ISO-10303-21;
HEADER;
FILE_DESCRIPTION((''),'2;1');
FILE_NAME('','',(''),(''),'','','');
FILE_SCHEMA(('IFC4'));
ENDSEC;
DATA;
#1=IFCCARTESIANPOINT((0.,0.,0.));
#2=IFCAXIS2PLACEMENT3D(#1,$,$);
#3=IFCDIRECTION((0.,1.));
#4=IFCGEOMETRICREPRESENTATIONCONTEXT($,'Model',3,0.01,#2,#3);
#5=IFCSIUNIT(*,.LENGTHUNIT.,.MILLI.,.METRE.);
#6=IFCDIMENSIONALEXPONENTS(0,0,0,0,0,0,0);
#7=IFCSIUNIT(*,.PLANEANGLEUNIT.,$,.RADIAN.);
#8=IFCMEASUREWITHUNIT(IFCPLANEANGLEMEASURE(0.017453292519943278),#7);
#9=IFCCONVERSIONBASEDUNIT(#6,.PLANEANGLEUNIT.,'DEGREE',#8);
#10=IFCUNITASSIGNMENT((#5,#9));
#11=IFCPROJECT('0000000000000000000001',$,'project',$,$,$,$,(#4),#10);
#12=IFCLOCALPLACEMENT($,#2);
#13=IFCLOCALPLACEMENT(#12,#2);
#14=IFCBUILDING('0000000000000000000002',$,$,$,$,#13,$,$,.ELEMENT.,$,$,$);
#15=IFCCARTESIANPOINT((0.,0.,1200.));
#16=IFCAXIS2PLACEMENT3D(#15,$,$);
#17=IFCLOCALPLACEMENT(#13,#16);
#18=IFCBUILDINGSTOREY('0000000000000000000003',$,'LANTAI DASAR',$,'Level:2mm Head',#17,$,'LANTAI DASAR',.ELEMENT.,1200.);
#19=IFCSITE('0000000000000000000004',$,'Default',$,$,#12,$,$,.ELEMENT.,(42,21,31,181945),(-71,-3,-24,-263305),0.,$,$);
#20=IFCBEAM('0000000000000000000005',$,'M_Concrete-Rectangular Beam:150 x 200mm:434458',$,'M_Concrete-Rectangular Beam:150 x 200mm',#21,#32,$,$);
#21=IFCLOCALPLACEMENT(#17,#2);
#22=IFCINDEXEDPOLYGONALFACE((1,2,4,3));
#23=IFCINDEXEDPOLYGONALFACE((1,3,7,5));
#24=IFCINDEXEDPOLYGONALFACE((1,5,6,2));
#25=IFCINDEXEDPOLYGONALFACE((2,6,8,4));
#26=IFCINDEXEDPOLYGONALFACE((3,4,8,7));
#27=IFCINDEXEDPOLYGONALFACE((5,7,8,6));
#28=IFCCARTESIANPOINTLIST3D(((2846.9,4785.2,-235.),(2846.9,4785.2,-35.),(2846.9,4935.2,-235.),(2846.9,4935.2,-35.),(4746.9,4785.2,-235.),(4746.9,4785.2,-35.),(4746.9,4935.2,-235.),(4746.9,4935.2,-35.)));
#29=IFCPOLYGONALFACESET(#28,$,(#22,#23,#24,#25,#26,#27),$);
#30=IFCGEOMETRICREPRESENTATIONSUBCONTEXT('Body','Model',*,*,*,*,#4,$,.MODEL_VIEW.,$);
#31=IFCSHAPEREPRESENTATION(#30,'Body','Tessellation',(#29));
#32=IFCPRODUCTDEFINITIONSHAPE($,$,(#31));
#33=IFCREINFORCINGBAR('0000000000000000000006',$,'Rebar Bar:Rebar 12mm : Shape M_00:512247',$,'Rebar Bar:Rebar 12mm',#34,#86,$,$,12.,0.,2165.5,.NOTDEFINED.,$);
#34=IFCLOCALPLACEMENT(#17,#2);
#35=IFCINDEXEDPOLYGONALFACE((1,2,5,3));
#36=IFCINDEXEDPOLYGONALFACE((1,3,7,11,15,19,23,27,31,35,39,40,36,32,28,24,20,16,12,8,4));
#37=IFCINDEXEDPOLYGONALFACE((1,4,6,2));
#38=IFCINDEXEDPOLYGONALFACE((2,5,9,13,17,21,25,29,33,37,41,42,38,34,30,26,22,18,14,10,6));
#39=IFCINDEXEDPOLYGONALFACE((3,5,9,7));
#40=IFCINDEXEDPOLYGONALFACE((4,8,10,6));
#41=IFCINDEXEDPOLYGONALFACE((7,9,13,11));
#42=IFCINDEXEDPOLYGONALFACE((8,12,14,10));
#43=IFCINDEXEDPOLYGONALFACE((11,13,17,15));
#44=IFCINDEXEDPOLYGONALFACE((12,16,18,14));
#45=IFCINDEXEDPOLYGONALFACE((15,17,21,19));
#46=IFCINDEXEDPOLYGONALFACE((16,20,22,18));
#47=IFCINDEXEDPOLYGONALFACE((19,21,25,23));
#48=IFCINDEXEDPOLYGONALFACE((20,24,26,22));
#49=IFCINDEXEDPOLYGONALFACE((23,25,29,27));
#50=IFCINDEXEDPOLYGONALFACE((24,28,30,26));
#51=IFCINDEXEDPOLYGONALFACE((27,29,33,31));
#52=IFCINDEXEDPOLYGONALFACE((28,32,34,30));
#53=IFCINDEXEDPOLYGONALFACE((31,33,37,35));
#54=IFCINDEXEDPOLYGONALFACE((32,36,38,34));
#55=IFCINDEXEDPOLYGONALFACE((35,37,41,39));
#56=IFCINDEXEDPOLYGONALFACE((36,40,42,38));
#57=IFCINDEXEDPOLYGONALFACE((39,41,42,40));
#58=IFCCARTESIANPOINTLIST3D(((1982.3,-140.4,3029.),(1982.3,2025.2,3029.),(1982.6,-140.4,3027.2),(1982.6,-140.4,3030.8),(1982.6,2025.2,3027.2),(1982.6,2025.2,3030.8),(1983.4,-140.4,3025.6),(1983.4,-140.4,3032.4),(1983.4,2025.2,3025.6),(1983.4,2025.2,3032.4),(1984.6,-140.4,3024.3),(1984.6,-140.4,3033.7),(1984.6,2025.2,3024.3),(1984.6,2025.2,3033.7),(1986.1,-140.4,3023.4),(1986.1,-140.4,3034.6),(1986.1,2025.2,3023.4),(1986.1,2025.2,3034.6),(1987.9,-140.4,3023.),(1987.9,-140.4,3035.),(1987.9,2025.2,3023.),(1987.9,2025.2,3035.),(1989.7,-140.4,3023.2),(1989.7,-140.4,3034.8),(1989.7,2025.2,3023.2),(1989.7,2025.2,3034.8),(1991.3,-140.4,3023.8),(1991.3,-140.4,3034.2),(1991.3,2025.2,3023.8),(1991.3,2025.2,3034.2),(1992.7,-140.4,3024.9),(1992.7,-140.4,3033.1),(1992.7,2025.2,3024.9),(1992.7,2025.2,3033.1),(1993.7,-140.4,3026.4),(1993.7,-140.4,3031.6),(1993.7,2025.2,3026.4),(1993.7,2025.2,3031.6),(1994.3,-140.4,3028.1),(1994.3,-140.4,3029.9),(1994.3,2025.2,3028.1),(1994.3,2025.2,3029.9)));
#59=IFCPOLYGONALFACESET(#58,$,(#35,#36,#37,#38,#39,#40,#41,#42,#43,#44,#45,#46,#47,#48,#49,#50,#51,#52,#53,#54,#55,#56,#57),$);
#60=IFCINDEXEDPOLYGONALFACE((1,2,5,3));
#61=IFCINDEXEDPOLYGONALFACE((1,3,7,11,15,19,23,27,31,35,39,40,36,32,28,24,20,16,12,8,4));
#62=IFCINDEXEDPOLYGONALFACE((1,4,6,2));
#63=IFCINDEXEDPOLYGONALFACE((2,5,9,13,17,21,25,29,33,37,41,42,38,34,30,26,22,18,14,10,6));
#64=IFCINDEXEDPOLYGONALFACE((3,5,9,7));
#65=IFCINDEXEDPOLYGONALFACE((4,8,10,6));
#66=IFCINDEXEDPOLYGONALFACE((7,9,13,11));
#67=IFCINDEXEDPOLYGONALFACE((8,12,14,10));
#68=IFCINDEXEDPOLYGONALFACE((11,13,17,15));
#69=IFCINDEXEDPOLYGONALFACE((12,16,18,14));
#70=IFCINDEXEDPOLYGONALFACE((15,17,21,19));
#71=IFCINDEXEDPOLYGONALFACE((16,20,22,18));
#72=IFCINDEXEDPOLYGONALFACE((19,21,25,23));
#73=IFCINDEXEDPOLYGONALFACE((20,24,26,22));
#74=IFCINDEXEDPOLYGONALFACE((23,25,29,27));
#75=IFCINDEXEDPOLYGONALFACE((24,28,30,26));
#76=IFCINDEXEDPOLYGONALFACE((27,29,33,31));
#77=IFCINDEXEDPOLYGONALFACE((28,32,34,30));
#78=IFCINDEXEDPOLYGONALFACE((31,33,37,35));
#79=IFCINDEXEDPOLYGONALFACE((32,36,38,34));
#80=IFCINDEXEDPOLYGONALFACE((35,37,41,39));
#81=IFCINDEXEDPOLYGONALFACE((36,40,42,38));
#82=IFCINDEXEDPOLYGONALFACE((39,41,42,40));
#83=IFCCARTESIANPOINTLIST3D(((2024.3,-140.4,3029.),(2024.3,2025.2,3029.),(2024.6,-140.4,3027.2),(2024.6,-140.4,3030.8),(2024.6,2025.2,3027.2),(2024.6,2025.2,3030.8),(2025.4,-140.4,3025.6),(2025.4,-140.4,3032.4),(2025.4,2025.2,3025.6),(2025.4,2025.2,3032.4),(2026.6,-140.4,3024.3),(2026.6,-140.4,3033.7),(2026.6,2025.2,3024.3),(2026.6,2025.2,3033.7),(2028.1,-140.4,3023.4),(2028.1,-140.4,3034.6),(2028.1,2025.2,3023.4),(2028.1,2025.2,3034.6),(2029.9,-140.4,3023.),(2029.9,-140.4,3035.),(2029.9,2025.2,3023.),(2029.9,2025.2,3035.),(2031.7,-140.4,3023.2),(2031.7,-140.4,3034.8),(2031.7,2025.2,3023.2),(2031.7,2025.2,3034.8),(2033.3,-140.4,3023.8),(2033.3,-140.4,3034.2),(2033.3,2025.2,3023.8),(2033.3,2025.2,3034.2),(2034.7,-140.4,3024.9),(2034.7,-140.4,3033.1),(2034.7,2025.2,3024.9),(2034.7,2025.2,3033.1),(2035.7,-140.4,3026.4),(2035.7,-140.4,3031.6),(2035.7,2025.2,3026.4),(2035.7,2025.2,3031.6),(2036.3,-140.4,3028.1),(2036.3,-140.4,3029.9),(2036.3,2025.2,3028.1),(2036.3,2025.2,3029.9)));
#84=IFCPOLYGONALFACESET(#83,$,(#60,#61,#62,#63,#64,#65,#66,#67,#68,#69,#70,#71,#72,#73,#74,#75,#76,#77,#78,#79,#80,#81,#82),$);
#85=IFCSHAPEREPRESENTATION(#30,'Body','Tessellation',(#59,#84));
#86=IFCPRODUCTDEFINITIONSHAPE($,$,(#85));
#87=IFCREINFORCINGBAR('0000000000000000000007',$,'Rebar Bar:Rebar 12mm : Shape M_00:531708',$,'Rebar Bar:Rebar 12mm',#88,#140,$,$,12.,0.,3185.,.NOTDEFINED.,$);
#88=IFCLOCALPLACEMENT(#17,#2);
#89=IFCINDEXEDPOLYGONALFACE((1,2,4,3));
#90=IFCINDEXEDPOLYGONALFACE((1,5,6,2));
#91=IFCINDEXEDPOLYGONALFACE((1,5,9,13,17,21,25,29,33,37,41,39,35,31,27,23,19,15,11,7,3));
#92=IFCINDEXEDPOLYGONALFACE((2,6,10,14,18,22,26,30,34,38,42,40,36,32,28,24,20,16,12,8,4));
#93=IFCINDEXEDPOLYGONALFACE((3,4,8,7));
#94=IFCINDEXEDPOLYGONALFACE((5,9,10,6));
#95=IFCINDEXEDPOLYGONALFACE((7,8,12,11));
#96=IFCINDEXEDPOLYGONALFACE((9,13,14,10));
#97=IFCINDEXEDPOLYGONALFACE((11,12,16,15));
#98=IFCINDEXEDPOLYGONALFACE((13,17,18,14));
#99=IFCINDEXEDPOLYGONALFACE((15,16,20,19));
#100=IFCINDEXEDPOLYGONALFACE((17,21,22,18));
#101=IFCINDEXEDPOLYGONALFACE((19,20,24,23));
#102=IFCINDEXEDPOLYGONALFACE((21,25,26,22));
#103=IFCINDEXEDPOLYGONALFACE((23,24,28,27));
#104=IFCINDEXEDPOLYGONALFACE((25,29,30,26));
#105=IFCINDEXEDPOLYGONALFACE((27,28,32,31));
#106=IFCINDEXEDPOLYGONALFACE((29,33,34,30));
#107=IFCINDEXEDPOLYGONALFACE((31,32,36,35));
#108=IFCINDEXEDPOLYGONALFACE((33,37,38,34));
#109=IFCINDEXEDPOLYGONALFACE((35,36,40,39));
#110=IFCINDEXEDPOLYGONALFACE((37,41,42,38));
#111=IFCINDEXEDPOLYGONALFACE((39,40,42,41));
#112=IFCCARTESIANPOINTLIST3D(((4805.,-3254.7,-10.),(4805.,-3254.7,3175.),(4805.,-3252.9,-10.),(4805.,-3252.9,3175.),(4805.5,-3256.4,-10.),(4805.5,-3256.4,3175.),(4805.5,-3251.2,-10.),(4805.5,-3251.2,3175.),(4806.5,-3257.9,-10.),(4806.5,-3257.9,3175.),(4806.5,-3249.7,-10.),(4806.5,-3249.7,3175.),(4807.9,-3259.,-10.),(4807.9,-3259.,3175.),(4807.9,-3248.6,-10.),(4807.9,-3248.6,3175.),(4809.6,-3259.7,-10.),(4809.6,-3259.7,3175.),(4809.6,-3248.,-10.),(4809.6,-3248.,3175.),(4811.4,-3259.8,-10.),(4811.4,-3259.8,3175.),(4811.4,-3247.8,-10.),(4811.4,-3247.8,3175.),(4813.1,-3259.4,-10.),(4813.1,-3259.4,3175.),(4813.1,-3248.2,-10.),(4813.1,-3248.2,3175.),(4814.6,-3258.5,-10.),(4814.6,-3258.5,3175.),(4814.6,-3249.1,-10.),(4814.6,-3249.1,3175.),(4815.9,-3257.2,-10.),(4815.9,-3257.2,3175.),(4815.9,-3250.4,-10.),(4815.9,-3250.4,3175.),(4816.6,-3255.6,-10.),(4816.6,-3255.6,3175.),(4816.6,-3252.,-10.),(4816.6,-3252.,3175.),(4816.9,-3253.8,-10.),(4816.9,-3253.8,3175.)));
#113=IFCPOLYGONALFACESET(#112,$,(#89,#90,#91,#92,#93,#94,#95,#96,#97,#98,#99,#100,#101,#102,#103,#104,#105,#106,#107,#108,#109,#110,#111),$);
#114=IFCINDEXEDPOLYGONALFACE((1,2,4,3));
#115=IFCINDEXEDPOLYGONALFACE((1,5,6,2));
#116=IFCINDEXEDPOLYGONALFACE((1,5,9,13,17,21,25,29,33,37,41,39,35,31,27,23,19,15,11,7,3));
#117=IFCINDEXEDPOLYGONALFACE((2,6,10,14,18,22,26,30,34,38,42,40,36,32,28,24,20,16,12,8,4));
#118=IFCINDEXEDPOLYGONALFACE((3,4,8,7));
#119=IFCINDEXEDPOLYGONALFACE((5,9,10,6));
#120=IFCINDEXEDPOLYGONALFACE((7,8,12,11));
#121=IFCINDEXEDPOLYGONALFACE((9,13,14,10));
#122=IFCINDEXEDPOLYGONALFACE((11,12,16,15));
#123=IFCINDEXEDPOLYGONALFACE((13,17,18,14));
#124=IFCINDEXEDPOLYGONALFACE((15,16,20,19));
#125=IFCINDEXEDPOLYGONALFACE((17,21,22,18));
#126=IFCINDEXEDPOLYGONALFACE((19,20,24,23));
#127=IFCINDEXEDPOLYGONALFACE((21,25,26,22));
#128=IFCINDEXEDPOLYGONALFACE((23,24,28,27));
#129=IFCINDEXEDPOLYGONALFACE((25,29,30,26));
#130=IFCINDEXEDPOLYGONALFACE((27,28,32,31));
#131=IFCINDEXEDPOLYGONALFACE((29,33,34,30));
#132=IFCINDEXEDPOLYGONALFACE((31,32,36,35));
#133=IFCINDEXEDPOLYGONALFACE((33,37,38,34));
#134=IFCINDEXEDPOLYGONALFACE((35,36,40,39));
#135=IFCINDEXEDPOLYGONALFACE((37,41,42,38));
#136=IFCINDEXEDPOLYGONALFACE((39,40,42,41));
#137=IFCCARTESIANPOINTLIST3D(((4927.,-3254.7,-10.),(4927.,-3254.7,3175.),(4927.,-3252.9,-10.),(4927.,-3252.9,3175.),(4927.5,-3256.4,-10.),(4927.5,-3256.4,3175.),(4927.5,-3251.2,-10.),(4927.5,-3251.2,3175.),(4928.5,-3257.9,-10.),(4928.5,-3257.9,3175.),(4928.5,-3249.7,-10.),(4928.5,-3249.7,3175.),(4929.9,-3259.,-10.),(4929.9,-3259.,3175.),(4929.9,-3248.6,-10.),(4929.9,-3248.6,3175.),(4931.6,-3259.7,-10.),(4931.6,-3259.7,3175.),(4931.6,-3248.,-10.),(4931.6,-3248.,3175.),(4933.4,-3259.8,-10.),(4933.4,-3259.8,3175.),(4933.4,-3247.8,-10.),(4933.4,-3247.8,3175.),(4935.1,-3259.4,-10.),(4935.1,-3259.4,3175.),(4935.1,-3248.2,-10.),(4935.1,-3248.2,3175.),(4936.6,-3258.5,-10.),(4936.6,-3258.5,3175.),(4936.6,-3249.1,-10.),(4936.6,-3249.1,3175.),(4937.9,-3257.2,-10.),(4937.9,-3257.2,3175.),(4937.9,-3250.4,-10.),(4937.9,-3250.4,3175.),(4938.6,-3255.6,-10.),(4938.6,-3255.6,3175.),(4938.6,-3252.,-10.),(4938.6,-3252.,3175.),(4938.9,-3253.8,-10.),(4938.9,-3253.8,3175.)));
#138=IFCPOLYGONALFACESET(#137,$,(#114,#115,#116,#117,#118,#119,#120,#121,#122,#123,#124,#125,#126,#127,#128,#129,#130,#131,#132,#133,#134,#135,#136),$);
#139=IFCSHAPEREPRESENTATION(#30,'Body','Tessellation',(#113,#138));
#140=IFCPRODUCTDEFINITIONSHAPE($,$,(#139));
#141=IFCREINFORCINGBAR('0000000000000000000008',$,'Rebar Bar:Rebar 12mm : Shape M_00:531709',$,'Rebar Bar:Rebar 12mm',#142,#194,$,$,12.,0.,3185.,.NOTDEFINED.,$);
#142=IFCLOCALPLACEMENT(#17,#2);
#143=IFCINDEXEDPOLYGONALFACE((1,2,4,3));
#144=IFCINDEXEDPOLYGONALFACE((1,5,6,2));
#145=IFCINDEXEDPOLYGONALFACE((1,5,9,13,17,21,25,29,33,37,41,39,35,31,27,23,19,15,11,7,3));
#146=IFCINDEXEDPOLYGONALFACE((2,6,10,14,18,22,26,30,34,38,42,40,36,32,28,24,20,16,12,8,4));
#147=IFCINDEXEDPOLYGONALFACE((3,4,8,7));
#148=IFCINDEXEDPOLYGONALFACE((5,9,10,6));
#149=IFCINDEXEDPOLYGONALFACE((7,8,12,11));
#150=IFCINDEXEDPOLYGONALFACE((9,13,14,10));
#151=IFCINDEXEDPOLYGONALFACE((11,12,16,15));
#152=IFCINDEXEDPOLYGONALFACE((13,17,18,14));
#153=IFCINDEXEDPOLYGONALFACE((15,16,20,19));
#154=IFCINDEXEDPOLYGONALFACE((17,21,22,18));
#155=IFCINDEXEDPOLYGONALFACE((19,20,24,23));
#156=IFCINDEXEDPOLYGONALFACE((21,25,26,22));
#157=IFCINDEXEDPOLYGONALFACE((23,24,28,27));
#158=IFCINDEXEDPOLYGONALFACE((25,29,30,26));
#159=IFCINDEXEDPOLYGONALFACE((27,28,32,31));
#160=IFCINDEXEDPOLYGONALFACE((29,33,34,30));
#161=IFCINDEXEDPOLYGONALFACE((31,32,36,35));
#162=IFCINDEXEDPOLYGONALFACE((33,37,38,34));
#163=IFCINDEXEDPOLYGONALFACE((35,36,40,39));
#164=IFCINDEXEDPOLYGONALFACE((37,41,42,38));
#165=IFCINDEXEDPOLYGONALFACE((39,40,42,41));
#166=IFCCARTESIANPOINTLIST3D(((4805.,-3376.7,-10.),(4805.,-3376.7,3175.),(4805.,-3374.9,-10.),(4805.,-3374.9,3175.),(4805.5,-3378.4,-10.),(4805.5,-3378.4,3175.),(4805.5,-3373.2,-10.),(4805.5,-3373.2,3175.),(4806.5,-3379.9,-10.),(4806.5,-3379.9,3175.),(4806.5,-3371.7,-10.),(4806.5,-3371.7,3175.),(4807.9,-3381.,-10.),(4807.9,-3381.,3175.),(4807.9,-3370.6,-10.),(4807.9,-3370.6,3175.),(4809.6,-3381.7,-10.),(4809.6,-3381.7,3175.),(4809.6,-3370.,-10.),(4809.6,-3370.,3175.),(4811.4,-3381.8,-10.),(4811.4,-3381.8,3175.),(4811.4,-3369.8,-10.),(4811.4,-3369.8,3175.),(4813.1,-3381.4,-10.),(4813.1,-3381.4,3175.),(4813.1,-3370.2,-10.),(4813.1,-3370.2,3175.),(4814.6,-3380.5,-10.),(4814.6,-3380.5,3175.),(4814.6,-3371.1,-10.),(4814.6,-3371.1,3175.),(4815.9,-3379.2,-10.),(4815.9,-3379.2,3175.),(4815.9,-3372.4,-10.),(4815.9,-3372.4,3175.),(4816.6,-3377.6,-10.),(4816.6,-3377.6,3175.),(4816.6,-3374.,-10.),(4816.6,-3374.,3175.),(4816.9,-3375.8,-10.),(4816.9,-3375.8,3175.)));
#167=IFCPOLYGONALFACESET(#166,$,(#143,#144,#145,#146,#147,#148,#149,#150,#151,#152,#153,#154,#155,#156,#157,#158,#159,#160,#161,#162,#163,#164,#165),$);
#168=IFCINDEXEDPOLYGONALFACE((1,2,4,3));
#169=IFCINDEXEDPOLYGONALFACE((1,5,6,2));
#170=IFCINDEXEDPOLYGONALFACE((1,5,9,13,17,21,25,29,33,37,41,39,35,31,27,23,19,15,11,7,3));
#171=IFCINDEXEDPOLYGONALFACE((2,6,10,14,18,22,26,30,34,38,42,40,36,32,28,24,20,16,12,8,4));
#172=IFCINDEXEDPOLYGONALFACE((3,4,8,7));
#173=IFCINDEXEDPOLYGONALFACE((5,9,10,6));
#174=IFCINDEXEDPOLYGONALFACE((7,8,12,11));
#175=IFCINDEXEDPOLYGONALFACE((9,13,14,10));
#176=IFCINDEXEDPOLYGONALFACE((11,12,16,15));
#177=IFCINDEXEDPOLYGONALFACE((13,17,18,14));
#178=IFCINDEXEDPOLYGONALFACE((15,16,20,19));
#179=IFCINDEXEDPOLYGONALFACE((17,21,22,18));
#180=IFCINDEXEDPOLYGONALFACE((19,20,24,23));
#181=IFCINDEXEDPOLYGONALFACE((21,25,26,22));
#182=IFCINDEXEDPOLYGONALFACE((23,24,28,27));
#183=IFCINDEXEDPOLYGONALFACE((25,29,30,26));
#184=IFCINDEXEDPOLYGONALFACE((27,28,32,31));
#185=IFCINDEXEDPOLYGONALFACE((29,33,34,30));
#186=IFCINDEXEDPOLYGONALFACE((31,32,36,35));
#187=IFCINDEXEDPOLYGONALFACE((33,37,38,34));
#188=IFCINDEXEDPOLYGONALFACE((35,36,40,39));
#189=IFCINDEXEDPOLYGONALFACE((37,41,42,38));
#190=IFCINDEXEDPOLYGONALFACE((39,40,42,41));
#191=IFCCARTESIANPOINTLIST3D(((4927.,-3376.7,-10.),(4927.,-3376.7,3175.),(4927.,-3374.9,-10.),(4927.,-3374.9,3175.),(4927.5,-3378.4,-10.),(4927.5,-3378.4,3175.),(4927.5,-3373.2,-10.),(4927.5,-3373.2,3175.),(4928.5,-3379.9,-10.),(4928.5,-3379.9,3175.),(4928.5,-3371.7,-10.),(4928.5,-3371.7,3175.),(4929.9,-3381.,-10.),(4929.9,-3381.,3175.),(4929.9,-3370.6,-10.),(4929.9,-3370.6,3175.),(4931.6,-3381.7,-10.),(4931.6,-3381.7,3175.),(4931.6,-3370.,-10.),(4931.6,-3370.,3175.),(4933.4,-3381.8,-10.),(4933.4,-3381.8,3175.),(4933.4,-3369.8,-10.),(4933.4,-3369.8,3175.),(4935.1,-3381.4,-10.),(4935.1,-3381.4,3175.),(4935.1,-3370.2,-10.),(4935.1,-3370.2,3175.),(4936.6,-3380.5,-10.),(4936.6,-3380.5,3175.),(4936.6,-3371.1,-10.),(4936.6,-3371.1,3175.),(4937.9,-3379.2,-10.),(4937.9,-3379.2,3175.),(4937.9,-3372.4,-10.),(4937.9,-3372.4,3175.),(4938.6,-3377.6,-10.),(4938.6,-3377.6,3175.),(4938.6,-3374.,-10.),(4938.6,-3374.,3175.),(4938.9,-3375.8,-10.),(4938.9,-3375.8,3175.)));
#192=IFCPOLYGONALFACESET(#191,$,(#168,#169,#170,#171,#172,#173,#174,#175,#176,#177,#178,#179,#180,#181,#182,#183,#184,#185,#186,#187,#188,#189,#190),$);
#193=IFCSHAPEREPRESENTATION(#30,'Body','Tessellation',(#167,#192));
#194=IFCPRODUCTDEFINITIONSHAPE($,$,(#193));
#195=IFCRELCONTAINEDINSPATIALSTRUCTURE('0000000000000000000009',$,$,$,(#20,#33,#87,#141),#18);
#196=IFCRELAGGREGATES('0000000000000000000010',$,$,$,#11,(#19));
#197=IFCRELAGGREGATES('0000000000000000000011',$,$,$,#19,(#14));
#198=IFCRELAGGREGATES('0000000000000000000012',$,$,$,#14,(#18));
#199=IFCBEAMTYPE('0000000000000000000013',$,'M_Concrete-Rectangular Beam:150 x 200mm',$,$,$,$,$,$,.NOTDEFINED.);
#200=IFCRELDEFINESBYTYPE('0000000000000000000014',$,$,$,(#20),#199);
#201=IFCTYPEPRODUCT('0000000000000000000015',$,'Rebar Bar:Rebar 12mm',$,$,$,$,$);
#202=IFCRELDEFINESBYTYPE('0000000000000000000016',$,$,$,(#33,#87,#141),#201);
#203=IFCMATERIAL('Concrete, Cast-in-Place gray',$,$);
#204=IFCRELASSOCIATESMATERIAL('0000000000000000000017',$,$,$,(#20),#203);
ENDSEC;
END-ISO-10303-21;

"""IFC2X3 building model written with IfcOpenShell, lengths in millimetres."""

from ifc_helpers import new_model, entity, si_unit, converted_unit, direction, frame, frame_2d, origin, place, context, subcontext, project, spatial, rectangle, extrude, material, type_object, element, save


model = new_model("IFC2X3")

# Units and contexts
model_context = context("Model", 3, precision=0.01, world=origin(), true_north=direction((0.0, 1.0)))
body_context = subcontext(model_context, "Body", "Model", "MODEL_VIEW")
ifc_project = project(units=[si_unit("LENGTHUNIT", "METRE", prefix="MILLI"), converted_unit("PLANEANGLEUNIT", "DEGREE", entity("IfcPlaneAngleMeasure", 0.017453292519943278), si_unit("PLANEANGLEUNIT", "RADIAN"), dimensions=[0, 0, 0, 0, 0, 0, 0])], contexts=[model_context])

# Site, building, storey
site_placement = place(None, origin())
site = spatial("IfcSite", under=ifc_project, at=site_placement, Name="Default", CompositionType="ELEMENT", RefLatitude=(42, 21, 31, 181945), RefLongitude=(-71, -3, -24, -263305), RefElevation=0.0)
building_placement = place(site_placement, origin())
building = spatial("IfcBuilding", under=site, at=building_placement, CompositionType="ELEMENT")
storey_placement = place(building_placement, frame((0.0, 0.0, 1200.0)))
storey = spatial("IfcBuildingStorey", under=building, at=storey_placement, Name="LANTAI DASAR", ObjectType="Level:2mm Head", LongName="LANTAI DASAR", CompositionType="ELEMENT", Elevation=1200.0)

# Shared definitions
ifc_material = material(Name="Concrete, Cast-in-Place gray")

# Beam
beam_type = type_object("IfcBeamType", Name="M_Concrete-Rectangular Beam:150 x 200mm", PredefinedType="NOTDEFINED")
beam_1_placement = place(storey_placement, frame((2721.9, 4860.2, -35.0)))
element("IfcBeam", 1, at=beam_1_placement, inside=storey, type_object=beam_type, material=ifc_material, Name="M_Concrete-Rectangular Beam:150 x 200mm:434458", ObjectType="M_Concrete-Rectangular Beam:150 x 200mm", context=body_context, shape_type="SweptSolid", body=[
    extrude(rectangle(XDim=200.0, YDim=150.0, at=frame_2d((0.0, 0.0), x_axis=(1.0, 0.0))), frame((125.0, 0.0, -100.0), z_axis=(1.0, 0.0, 0.0), x_axis=(0.0, 0.0, -1.0)), (0.0, 0.0, 1.0), 1900.0),
])

# Reinforcing bars
type_product_1 = type_object("IfcTypeProduct", Name="Rebar Bar:Rebar 12mm")
reinforcing_bar_1_placement = place(storey_placement, origin())
element("IfcReinforcingBar", 2, at=reinforcing_bar_1_placement, inside=storey, type_object=type_product_1, Name="Rebar Bar:Rebar 12mm : Shape M_00:512247", ObjectType="Rebar Bar:Rebar 12mm", BarLength=2165.5, BarRole="NOTDEFINED", CrossSectionArea=0.0, NominalDiameter=12.0, context=body_context, shape_type="AdvancedSweptSolid", body=[
    entity("IfcSweptDiskSolid", entity("IfcCompositeCurve", [entity("IfcCompositeCurveSegment", "CONTINUOUS", True, entity("IfcPolyline", [entity("IfcCartesianPoint", [1988.3, 2025.2, 3029.0]), entity("IfcCartesianPoint", [1988.3, -140.4, 3029.0])]))], False), 6.0, None, 0.0, 1.0),
    entity("IfcSweptDiskSolid", entity("IfcCompositeCurve", [entity("IfcCompositeCurveSegment", "CONTINUOUS", True, entity("IfcPolyline", [entity("IfcCartesianPoint", [2030.3, 2025.2, 3029.0]), entity("IfcCartesianPoint", [2030.3, -140.4, 3029.0])]))], False), 6.0, None, 0.0, 1.0),
])
reinforcing_bar_2_placement = place(storey_placement, origin())
element("IfcReinforcingBar", 3, at=reinforcing_bar_2_placement, inside=storey, type_object=type_product_1, Name="Rebar Bar:Rebar 12mm : Shape M_00:531708", ObjectType="Rebar Bar:Rebar 12mm", BarLength=3185.0, BarRole="NOTDEFINED", CrossSectionArea=0.0, NominalDiameter=12.0, context=body_context, shape_type="AdvancedSweptSolid", body=[
    entity("IfcSweptDiskSolid", entity("IfcCompositeCurve", [entity("IfcCompositeCurveSegment", "CONTINUOUS", True, entity("IfcPolyline", [entity("IfcCartesianPoint", [4810.9, -3253.8, -10.0]), entity("IfcCartesianPoint", [4810.9, -3253.8, 3175.0])]))], False), 6.0, None, 0.0, 1.0),
    entity("IfcSweptDiskSolid", entity("IfcCompositeCurve", [entity("IfcCompositeCurveSegment", "CONTINUOUS", True, entity("IfcPolyline", [entity("IfcCartesianPoint", [4932.9, -3253.8, -10.0]), entity("IfcCartesianPoint", [4932.9, -3253.8, 3175.0])]))], False), 6.0, None, 0.0, 1.0),
])
reinforcing_bar_3_placement = place(storey_placement, origin())
element("IfcReinforcingBar", 4, at=reinforcing_bar_3_placement, inside=storey, type_object=type_product_1, Name="Rebar Bar:Rebar 12mm : Shape M_00:531709", ObjectType="Rebar Bar:Rebar 12mm", BarLength=3185.0, BarRole="NOTDEFINED", CrossSectionArea=0.0, NominalDiameter=12.0, context=body_context, shape_type="AdvancedSweptSolid", body=[
    entity("IfcSweptDiskSolid", entity("IfcCompositeCurve", [entity("IfcCompositeCurveSegment", "CONTINUOUS", True, entity("IfcPolyline", [entity("IfcCartesianPoint", [4810.9, -3375.8, -10.0]), entity("IfcCartesianPoint", [4810.9, -3375.8, 3175.0])]))], False), 6.0, None, 0.0, 1.0),
    entity("IfcSweptDiskSolid", entity("IfcCompositeCurve", [entity("IfcCompositeCurveSegment", "CONTINUOUS", True, entity("IfcPolyline", [entity("IfcCartesianPoint", [4932.9, -3375.8, -10.0]), entity("IfcCartesianPoint", [4932.9, -3375.8, 3175.0])]))], False), 6.0, None, 0.0, 1.0),
])

save(model, "model.ifc")
